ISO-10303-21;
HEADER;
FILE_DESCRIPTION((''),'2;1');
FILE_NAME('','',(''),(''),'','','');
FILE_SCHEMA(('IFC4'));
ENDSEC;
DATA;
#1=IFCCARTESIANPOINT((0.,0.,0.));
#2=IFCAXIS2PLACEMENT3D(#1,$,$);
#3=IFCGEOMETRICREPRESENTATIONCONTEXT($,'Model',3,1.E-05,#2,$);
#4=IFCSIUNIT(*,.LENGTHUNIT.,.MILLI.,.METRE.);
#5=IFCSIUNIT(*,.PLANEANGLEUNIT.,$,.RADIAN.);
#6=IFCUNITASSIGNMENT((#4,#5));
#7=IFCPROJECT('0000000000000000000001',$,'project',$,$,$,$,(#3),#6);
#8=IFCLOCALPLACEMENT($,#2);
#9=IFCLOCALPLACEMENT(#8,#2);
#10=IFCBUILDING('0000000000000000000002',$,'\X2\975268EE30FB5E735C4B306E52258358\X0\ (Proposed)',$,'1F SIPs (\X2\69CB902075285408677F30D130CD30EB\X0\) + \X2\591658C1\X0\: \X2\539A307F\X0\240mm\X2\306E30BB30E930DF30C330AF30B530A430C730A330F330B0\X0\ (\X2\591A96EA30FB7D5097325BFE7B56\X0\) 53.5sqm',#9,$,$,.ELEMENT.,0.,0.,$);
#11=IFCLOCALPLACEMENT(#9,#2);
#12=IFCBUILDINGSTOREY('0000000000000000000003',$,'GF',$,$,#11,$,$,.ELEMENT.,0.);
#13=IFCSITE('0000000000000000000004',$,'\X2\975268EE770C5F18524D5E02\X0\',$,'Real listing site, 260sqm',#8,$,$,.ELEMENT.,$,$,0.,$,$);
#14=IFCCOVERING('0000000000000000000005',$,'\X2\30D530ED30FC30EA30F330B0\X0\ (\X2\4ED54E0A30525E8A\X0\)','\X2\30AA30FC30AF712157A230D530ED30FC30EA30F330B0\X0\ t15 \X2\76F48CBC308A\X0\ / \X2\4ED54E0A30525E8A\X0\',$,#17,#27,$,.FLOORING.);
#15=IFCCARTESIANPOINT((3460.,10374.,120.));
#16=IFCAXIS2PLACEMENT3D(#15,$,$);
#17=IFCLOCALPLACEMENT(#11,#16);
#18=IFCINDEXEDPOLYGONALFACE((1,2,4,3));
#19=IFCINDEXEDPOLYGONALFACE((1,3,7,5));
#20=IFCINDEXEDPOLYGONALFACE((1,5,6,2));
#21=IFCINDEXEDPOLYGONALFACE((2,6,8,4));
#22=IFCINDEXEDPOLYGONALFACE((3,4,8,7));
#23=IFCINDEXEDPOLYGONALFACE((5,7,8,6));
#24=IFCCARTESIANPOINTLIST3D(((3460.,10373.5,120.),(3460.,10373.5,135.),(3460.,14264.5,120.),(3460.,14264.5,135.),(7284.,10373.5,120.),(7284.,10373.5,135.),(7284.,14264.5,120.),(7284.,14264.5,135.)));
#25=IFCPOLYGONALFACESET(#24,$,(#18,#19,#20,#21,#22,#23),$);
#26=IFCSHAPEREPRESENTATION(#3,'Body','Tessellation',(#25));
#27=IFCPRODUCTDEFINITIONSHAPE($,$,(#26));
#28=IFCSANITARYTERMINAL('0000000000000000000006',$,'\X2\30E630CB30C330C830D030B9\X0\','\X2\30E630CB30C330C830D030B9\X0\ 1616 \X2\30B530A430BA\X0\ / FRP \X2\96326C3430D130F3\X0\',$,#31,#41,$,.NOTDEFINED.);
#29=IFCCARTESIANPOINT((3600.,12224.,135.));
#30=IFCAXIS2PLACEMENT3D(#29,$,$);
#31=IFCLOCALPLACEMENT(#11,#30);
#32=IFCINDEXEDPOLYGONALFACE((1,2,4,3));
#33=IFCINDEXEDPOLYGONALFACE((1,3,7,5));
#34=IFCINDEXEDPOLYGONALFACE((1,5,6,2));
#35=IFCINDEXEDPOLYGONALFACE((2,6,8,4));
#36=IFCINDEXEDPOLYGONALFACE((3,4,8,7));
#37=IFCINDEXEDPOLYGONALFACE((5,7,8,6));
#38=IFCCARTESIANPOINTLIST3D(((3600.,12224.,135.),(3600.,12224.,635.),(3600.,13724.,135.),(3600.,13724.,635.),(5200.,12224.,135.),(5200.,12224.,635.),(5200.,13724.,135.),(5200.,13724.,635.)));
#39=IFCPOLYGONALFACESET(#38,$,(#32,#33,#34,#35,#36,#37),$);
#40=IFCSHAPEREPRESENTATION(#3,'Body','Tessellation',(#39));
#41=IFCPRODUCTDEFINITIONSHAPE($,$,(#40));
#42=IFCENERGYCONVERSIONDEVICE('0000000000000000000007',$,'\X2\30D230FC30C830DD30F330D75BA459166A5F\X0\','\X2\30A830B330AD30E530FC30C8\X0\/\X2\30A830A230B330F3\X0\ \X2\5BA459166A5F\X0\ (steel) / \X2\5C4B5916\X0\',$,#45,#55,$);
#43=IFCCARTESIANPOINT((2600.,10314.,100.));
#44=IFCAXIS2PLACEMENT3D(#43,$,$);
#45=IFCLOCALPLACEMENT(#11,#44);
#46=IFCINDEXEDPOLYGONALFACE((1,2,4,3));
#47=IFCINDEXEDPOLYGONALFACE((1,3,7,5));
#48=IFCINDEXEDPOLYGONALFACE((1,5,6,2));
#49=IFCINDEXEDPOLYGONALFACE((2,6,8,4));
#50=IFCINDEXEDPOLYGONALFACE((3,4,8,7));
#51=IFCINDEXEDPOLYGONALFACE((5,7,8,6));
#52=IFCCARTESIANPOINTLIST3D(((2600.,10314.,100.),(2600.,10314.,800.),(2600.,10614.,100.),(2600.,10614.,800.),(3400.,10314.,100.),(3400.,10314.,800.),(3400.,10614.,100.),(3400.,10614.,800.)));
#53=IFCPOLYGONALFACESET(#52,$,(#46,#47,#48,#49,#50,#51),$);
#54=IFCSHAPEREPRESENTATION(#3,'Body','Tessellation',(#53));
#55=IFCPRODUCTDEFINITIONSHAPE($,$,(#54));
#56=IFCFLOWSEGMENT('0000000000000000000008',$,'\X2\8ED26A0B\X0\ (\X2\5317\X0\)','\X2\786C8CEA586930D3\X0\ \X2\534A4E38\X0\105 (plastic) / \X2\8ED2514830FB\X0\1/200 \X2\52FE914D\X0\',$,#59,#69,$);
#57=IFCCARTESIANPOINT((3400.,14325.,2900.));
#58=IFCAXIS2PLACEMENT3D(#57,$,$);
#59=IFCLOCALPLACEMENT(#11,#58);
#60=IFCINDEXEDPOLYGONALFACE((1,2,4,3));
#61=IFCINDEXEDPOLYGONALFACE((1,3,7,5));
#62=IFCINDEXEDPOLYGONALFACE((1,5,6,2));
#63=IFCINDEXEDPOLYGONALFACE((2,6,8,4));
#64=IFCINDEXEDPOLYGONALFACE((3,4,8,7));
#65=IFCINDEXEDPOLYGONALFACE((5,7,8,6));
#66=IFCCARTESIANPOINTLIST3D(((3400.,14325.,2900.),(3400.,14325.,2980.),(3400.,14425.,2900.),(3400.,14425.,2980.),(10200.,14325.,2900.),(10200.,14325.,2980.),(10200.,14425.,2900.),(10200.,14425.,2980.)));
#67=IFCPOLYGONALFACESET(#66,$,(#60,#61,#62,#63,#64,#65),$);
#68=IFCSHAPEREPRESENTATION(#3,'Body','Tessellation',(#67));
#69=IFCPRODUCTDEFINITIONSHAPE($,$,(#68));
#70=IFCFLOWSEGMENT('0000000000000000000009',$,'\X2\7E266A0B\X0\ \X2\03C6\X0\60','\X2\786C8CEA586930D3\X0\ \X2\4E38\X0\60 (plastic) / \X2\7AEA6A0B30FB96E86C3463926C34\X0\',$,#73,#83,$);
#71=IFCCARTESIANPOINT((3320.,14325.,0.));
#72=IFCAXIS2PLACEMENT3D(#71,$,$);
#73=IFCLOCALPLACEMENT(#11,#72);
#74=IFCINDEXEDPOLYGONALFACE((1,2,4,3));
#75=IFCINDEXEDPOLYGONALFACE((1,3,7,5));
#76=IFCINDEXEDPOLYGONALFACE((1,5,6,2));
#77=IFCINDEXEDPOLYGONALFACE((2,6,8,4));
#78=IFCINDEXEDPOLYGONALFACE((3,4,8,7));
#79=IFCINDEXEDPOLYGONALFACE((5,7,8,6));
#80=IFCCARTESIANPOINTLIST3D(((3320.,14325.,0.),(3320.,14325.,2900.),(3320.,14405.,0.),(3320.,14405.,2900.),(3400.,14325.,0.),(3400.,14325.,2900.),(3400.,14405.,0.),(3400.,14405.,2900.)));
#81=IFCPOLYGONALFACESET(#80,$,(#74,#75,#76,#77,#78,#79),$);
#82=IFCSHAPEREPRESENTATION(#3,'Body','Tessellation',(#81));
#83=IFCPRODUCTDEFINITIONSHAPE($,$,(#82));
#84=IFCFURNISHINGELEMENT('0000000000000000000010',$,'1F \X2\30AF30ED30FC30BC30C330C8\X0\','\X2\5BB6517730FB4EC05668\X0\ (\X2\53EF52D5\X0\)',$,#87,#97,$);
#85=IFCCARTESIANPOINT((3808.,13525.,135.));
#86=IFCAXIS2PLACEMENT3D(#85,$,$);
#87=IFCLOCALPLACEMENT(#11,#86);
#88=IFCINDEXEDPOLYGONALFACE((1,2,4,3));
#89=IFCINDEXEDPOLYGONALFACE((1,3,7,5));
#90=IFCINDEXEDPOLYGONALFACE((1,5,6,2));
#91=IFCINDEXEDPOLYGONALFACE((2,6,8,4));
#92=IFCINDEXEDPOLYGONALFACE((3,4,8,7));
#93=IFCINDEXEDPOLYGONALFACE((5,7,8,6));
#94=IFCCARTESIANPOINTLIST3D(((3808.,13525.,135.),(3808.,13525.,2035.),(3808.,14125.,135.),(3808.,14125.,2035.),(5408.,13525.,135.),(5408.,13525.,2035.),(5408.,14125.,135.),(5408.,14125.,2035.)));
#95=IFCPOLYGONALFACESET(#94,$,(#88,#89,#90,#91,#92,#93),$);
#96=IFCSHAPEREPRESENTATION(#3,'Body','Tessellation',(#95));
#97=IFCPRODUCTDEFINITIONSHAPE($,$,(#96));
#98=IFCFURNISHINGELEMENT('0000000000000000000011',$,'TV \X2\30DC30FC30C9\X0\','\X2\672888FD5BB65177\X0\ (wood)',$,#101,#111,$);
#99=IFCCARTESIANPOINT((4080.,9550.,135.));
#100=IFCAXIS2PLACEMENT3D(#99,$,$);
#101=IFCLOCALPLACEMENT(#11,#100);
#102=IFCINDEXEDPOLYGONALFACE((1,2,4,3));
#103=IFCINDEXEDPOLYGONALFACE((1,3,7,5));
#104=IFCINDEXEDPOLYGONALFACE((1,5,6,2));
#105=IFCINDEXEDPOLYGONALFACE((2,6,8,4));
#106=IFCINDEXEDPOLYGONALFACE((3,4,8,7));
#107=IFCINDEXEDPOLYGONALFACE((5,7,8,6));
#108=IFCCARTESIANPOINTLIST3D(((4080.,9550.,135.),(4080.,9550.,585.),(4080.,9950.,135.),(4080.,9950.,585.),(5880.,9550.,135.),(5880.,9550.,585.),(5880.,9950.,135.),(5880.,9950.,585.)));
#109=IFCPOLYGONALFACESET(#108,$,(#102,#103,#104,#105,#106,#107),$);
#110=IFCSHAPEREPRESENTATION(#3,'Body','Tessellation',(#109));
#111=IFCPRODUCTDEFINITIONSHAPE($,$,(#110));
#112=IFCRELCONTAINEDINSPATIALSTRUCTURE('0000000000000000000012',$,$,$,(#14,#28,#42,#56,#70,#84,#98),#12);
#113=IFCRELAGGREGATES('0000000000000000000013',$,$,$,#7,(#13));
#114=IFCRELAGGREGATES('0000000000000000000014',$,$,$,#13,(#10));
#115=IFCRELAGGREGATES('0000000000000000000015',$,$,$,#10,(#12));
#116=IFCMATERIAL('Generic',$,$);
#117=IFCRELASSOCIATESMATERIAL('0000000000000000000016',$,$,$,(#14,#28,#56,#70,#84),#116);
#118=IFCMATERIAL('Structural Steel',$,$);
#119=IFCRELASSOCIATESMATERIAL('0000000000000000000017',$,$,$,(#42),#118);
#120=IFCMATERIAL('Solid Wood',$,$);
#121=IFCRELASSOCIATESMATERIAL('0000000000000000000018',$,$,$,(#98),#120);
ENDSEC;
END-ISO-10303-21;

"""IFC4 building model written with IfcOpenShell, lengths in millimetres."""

from ifc_helpers import new_model, si_unit, frame, frame_2d, origin, place, context, project, spatial, rectangle, extrude, material, element, save


model = new_model("IFC4")

# Units and contexts
model_context = context("Model", 3, precision=1e-05, world=origin())
ifc_project = project(units=[si_unit("LENGTHUNIT", "METRE", prefix="MILLI"), si_unit("PLANEANGLEUNIT", "RADIAN")], contexts=[model_context])

# Site, building, storey
site_placement = place(None, origin())
site = spatial("IfcSite", under=ifc_project, at=site_placement, Name="青森県弘前市", ObjectType="Real listing site, 260sqm", CompositionType="ELEMENT", RefElevation=0.0)
building_placement = place(site_placement, origin())
building = spatial("IfcBuilding", under=site, at=building_placement, Name="青森・平屋の別荘 (Proposed)", ObjectType="1F SIPs (構造用合板パネル) + 外壁: 厚み240mmのセラミックサイディング (多雪・結露対策) 53.5sqm", CompositionType="ELEMENT", ElevationOfRefHeight=0.0, ElevationOfTerrain=0.0)
storey_placement = place(building_placement, origin())
storey = spatial("IfcBuildingStorey", under=building, at=storey_placement, Name="GF", CompositionType="ELEMENT", Elevation=0.0)

# Shared definitions
ifc_material_1 = material(Name="Solid Wood")

# Shared definitions
ifc_material_2 = material(Name="Structural Steel")

# Covering
ifc_material_3 = material(Name="Generic")
covering_placement = place(storey_placement, frame((3460.0, 10374.0, 120.0)))
element("IfcCovering", 1, at=covering_placement, inside=storey, material=ifc_material_3, Name="フローリング (仕上げ床)", Description="オーク無垢フローリング t15 直貼り / 仕上げ床", PredefinedType="FLOORING", context=model_context, shape_type="SweptSolid", body=[
    extrude(rectangle(XDim=3824.0, YDim=3891.0, at=frame_2d((1912.0, 1945.0))), frame((3460.0, 10374.0, 120.0)), (0.0, 0.0, 1.0), 15.0),
])

# Sanitary terminal
sanitary_terminal_placement = place(storey_placement, frame((3600.0, 12224.0, 135.0)))
element("IfcSanitaryTerminal", 2, at=sanitary_terminal_placement, inside=storey, material=ifc_material_3, Name="ユニットバス", Description="ユニットバス 1616 サイズ / FRP 防水パン", PredefinedType="NOTDEFINED", context=model_context, shape_type="SweptSolid", body=[
    extrude(rectangle(XDim=1600.0, YDim=1500.0, at=frame_2d((800.0, 750.0))), frame((3600.0, 12224.0, 135.0)), (0.0, 0.0, 1.0), 500.0),
])

# Energy conversion device
energy_conversion_device_placement = place(storey_placement, frame((2600.0, 10314.0, 100.0)))
element("IfcEnergyConversionDevice", 3, at=energy_conversion_device_placement, inside=storey, material=ifc_material_2, Name="ヒートポンプ室外機", Description="エコキュート/エアコン 室外機 (steel) / 屋外", context=model_context, shape_type="SweptSolid", body=[
    extrude(rectangle(XDim=800.0, YDim=300.0, at=frame_2d((400.0, 150.0))), frame((2600.0, 10314.0, 100.0)), (0.0, 0.0, 1.0), 700.0),
])

# Flow segments
flow_segment_1_placement = place(storey_placement, frame((3400.0, 14325.0, 2900.0)))
element("IfcFlowSegment", 4, at=flow_segment_1_placement, inside=storey, material=ifc_material_3, Name="軒樋 (北)", Description="硬質塩ビ 半丸105 (plastic) / 軒先・1/200 勾配", context=model_context, shape_type="SweptSolid", body=[
    extrude(rectangle(XDim=6800.0, YDim=100.0, at=frame_2d((3400.0, 50.0))), frame((3400.0, 14325.0, 2900.0)), (0.0, 0.0, 1.0), 80.0),
])
flow_segment_2_placement = place(storey_placement, frame((3320.0, 14325.0, 0.0)))
element("IfcFlowSegment", 5, at=flow_segment_2_placement, inside=storey, material=ifc_material_3, Name="縦樋 φ60", Description="硬質塩ビ 丸60 (plastic) / 竪樋・雨水排水", context=model_context, shape_type="SweptSolid", body=[
    extrude(rectangle(XDim=80.0, YDim=80.0, at=frame_2d((40.0, 40.0))), frame((3320.0, 14325.0, 0.0)), (0.0, 0.0, 1.0), 2900.0),
])

# Furnishing elements
furnishing_1_placement = place(storey_placement, frame((3808.0, 13525.0, 135.0)))
element("IfcFurnishingElement", 6, at=furnishing_1_placement, inside=storey, material=ifc_material_3, Name="1F クローゼット", Description="家具・什器 (可動)", context=model_context, shape_type="SweptSolid", body=[
    extrude(rectangle(XDim=1600.0, YDim=600.0, at=frame_2d((800.0, 300.0))), frame((3808.0, 13525.0, 135.0)), (0.0, 0.0, 1.0), 1900.0),
])
furnishing_2_placement = place(storey_placement, frame((4080.0, 9550.0, 135.0)))
element("IfcFurnishingElement", 7, at=furnishing_2_placement, inside=storey, material=ifc_material_1, Name="TV ボード", Description="木製家具 (wood)", context=model_context, shape_type="SweptSolid", body=[
    extrude(rectangle(XDim=1800.0, YDim=400.0, at=frame_2d((900.0, 200.0))), frame((4080.0, 9550.0, 135.0)), (0.0, 0.0, 1.0), 450.0),
])

save(model, "model.ifc")
